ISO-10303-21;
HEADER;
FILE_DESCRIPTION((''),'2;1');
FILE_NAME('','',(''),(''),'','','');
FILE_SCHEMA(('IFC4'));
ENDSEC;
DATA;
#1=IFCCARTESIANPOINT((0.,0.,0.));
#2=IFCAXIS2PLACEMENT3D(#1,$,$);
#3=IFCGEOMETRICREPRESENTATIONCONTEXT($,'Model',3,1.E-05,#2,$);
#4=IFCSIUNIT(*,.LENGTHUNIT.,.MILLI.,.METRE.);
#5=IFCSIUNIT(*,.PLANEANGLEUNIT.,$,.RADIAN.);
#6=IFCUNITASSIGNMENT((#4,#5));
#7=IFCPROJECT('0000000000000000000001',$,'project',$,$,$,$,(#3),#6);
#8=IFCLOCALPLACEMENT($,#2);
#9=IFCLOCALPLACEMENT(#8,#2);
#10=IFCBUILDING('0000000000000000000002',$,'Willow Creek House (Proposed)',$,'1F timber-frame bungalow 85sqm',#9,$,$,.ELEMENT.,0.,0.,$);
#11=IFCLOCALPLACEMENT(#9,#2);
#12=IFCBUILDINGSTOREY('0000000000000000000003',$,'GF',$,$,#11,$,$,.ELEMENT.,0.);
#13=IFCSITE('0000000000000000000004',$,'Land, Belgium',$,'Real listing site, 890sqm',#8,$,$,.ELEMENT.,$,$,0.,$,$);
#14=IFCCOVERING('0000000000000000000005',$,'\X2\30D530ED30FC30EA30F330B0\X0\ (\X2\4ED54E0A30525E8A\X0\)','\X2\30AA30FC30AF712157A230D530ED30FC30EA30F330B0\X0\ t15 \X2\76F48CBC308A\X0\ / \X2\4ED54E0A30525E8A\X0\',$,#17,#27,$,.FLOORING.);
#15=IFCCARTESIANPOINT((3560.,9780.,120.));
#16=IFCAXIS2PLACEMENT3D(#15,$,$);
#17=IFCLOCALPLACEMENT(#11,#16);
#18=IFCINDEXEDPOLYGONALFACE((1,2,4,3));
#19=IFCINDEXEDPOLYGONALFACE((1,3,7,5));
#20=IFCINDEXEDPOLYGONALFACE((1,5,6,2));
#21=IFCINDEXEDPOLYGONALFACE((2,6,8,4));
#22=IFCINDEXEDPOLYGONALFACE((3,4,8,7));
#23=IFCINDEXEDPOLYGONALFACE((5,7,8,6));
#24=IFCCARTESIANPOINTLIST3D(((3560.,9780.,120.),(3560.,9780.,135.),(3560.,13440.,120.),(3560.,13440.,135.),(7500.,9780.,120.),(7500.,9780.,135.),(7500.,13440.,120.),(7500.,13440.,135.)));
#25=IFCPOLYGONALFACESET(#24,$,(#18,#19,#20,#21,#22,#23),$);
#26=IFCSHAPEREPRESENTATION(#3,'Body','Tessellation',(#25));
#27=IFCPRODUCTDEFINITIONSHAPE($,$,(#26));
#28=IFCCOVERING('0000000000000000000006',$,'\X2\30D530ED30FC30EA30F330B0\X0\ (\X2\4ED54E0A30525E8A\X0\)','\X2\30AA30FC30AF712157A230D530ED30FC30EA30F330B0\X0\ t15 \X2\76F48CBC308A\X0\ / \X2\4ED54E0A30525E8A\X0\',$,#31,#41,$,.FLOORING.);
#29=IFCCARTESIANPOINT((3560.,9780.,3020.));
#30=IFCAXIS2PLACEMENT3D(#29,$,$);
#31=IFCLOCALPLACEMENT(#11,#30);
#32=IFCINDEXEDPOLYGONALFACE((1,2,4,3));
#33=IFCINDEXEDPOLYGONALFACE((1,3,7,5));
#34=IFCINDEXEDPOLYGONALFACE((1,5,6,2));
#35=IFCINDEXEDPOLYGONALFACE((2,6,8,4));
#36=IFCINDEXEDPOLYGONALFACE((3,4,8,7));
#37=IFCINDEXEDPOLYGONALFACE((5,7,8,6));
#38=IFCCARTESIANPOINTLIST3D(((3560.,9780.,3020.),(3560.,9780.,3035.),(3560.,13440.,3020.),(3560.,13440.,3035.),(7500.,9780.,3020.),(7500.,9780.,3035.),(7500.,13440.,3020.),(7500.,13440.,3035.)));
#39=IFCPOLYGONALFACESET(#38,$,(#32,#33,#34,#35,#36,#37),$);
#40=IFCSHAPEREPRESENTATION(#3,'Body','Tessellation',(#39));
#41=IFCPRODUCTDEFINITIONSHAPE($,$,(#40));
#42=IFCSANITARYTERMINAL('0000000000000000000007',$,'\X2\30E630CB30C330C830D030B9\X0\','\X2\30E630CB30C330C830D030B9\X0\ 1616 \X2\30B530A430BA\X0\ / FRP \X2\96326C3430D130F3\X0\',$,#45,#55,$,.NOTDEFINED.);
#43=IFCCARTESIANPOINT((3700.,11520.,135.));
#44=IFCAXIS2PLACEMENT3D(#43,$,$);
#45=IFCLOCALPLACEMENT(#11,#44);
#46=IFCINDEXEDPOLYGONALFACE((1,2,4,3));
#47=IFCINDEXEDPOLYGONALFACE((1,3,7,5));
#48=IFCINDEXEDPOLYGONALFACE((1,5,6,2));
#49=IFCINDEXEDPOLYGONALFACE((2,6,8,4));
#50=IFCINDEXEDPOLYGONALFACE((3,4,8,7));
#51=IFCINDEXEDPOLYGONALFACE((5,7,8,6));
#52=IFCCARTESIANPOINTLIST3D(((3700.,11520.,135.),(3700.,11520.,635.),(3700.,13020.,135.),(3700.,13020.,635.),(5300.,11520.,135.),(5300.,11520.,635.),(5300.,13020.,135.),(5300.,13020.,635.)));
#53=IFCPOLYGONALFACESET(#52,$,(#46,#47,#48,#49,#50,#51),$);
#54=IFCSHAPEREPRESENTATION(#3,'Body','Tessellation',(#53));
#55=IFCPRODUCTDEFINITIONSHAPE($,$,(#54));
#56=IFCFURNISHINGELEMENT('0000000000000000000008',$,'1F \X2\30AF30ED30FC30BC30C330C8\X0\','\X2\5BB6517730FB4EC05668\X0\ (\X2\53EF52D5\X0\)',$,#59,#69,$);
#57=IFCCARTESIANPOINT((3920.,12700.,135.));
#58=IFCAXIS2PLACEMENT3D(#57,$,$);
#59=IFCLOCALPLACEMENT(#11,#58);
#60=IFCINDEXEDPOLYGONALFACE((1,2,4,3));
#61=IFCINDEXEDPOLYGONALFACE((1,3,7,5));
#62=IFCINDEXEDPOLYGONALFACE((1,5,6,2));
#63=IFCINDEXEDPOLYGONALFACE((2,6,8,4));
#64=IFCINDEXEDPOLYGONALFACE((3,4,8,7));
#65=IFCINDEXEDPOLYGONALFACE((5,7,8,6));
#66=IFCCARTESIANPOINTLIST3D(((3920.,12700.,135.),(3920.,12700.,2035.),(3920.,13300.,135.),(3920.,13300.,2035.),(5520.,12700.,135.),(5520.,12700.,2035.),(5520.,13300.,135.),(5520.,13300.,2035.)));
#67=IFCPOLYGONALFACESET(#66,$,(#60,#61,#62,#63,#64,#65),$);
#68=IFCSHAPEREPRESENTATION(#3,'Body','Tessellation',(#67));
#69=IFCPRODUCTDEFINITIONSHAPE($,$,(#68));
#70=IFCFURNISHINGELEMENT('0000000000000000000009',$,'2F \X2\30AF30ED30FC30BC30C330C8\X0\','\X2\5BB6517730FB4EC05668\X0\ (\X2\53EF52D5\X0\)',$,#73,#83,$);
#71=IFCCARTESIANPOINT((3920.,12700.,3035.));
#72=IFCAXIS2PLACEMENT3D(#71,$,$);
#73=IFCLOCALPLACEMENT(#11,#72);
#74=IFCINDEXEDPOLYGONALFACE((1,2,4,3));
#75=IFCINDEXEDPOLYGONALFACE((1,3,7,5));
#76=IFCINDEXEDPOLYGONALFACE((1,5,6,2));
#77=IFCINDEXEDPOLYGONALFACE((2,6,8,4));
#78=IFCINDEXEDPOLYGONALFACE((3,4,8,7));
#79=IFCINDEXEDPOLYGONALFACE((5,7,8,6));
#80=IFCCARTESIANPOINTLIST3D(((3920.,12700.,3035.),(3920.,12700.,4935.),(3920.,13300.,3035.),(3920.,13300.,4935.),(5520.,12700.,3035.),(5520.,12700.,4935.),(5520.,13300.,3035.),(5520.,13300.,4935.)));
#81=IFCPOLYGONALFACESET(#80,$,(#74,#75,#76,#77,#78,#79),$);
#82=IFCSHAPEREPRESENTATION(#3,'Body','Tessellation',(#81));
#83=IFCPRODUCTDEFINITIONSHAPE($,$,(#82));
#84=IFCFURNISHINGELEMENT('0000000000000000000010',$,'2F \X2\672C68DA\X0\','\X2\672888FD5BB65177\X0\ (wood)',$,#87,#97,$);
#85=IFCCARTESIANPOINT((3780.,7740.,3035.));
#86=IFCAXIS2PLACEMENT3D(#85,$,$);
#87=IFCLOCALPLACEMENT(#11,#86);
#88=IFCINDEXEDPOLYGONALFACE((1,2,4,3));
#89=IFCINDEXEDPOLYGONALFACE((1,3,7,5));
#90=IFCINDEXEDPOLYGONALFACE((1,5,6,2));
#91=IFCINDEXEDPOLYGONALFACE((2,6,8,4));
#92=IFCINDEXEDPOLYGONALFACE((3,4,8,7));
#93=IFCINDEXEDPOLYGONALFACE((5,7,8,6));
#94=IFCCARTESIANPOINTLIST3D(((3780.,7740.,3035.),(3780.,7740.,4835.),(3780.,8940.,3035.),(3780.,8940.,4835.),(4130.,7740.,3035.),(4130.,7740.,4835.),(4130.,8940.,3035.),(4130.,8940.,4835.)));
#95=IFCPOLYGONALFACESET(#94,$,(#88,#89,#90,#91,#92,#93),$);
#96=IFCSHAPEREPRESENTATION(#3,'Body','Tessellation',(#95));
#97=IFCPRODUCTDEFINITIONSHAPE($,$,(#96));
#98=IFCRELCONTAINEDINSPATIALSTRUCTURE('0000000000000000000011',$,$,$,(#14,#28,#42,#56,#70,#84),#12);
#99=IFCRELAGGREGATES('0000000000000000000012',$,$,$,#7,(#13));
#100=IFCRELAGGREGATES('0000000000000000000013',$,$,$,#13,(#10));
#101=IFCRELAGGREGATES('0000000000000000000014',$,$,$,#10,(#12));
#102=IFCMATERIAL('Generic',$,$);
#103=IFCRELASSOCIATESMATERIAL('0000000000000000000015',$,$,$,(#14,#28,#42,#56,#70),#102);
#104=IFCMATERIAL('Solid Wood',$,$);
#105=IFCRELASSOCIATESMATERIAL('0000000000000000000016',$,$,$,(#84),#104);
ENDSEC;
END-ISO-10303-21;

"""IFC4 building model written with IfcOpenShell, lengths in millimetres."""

from ifc_helpers import new_model, si_unit, frame, frame_2d, origin, place, context, project, spatial, rectangle, extrude, material, element, save


model = new_model("IFC4")

# Units and contexts
model_context = context("Model", 3, precision=1e-05, world=origin())
ifc_project = project(units=[si_unit("LENGTHUNIT", "METRE", prefix="MILLI"), si_unit("PLANEANGLEUNIT", "RADIAN")], contexts=[model_context])

# Site, building, storey
site_placement = place(None, origin())
site = spatial("IfcSite", under=ifc_project, at=site_placement, Name="Land, Belgium", ObjectType="Real listing site, 890sqm", CompositionType="ELEMENT", RefElevation=0.0)
building_placement = place(site_placement, origin())
building = spatial("IfcBuilding", under=site, at=building_placement, Name="Willow Creek House (Proposed)", ObjectType="1F timber-frame bungalow 85sqm", CompositionType="ELEMENT", ElevationOfRefHeight=0.0, ElevationOfTerrain=0.0)
storey_placement = place(building_placement, origin())
storey = spatial("IfcBuildingStorey", under=building, at=storey_placement, Name="GF", CompositionType="ELEMENT", Elevation=0.0)

# Shared definitions
ifc_material_1 = material(Name="Solid Wood")

# Coverings
ifc_material_2 = material(Name="Generic")
covering_1_placement = place(storey_placement, frame((3560.0, 9780.0, 120.0)))
element("IfcCovering", 1, at=covering_1_placement, inside=storey, material=ifc_material_2, Name="フローリング (仕上げ床)", Description="オーク無垢フローリング t15 直貼り / 仕上げ床", PredefinedType="FLOORING", context=model_context, shape_type="SweptSolid", body=[
    extrude(rectangle(XDim=3940.0, YDim=3660.0, at=frame_2d((1970.0, 1830.0))), frame((3560.0, 9780.0, 120.0)), (0.0, 0.0, 1.0), 15.0),
])
covering_2_placement = place(storey_placement, frame((3560.0, 9780.0, 3020.0)))
element("IfcCovering", 2, at=covering_2_placement, inside=storey, material=ifc_material_2, Name="フローリング (仕上げ床)", Description="オーク無垢フローリング t15 直貼り / 仕上げ床", PredefinedType="FLOORING", context=model_context, shape_type="SweptSolid", body=[
    extrude(rectangle(XDim=3940.0, YDim=3660.0, at=frame_2d((1970.0, 1830.0))), frame((3560.0, 9780.0, 3020.0)), (0.0, 0.0, 1.0), 15.0),
])

# Sanitary terminal
sanitary_terminal_placement = place(storey_placement, frame((3700.0, 11520.0, 135.0)))
element("IfcSanitaryTerminal", 3, at=sanitary_terminal_placement, inside=storey, material=ifc_material_2, Name="ユニットバス", Description="ユニットバス 1616 サイズ / FRP 防水パン", PredefinedType="NOTDEFINED", context=model_context, shape_type="SweptSolid", body=[
    extrude(rectangle(XDim=1600.0, YDim=1500.0, at=frame_2d((800.0, 750.0))), frame((3700.0, 11520.0, 135.0)), (0.0, 0.0, 1.0), 500.0),
])

# Furnishing elements
furnishing_1_placement = place(storey_placement, frame((3920.0, 12700.0, 135.0)))
element("IfcFurnishingElement", 4, at=furnishing_1_placement, inside=storey, material=ifc_material_2, Name="1F クローゼット", Description="家具・什器 (可動)", context=model_context, shape_type="SweptSolid", body=[
    extrude(rectangle(XDim=1600.0, YDim=600.0, at=frame_2d((800.0, 300.0))), frame((3920.0, 12700.0, 135.0)), (0.0, 0.0, 1.0), 1900.0),
])
furnishing_2_placement = place(storey_placement, frame((3920.0, 12700.0, 3035.0)))
element("IfcFurnishingElement", 5, at=furnishing_2_placement, inside=storey, material=ifc_material_2, Name="2F クローゼット", Description="家具・什器 (可動)", context=model_context, shape_type="SweptSolid", body=[
    extrude(rectangle(XDim=1600.0, YDim=600.0, at=frame_2d((800.0, 300.0))), frame((3920.0, 12700.0, 3035.0)), (0.0, 0.0, 1.0), 1900.0),
])
furnishing_3_placement = place(storey_placement, frame((3780.0, 7740.0, 3035.0)))
element("IfcFurnishingElement", 6, at=furnishing_3_placement, inside=storey, material=ifc_material_1, Name="2F 本棚", Description="木製家具 (wood)", context=model_context, shape_type="SweptSolid", body=[
    extrude(rectangle(XDim=350.0, YDim=1200.0, at=frame_2d((175.0, 600.0))), frame((3780.0, 7740.0, 3035.0)), (0.0, 0.0, 1.0), 1800.0),
])

save(model, "model.ifc")
